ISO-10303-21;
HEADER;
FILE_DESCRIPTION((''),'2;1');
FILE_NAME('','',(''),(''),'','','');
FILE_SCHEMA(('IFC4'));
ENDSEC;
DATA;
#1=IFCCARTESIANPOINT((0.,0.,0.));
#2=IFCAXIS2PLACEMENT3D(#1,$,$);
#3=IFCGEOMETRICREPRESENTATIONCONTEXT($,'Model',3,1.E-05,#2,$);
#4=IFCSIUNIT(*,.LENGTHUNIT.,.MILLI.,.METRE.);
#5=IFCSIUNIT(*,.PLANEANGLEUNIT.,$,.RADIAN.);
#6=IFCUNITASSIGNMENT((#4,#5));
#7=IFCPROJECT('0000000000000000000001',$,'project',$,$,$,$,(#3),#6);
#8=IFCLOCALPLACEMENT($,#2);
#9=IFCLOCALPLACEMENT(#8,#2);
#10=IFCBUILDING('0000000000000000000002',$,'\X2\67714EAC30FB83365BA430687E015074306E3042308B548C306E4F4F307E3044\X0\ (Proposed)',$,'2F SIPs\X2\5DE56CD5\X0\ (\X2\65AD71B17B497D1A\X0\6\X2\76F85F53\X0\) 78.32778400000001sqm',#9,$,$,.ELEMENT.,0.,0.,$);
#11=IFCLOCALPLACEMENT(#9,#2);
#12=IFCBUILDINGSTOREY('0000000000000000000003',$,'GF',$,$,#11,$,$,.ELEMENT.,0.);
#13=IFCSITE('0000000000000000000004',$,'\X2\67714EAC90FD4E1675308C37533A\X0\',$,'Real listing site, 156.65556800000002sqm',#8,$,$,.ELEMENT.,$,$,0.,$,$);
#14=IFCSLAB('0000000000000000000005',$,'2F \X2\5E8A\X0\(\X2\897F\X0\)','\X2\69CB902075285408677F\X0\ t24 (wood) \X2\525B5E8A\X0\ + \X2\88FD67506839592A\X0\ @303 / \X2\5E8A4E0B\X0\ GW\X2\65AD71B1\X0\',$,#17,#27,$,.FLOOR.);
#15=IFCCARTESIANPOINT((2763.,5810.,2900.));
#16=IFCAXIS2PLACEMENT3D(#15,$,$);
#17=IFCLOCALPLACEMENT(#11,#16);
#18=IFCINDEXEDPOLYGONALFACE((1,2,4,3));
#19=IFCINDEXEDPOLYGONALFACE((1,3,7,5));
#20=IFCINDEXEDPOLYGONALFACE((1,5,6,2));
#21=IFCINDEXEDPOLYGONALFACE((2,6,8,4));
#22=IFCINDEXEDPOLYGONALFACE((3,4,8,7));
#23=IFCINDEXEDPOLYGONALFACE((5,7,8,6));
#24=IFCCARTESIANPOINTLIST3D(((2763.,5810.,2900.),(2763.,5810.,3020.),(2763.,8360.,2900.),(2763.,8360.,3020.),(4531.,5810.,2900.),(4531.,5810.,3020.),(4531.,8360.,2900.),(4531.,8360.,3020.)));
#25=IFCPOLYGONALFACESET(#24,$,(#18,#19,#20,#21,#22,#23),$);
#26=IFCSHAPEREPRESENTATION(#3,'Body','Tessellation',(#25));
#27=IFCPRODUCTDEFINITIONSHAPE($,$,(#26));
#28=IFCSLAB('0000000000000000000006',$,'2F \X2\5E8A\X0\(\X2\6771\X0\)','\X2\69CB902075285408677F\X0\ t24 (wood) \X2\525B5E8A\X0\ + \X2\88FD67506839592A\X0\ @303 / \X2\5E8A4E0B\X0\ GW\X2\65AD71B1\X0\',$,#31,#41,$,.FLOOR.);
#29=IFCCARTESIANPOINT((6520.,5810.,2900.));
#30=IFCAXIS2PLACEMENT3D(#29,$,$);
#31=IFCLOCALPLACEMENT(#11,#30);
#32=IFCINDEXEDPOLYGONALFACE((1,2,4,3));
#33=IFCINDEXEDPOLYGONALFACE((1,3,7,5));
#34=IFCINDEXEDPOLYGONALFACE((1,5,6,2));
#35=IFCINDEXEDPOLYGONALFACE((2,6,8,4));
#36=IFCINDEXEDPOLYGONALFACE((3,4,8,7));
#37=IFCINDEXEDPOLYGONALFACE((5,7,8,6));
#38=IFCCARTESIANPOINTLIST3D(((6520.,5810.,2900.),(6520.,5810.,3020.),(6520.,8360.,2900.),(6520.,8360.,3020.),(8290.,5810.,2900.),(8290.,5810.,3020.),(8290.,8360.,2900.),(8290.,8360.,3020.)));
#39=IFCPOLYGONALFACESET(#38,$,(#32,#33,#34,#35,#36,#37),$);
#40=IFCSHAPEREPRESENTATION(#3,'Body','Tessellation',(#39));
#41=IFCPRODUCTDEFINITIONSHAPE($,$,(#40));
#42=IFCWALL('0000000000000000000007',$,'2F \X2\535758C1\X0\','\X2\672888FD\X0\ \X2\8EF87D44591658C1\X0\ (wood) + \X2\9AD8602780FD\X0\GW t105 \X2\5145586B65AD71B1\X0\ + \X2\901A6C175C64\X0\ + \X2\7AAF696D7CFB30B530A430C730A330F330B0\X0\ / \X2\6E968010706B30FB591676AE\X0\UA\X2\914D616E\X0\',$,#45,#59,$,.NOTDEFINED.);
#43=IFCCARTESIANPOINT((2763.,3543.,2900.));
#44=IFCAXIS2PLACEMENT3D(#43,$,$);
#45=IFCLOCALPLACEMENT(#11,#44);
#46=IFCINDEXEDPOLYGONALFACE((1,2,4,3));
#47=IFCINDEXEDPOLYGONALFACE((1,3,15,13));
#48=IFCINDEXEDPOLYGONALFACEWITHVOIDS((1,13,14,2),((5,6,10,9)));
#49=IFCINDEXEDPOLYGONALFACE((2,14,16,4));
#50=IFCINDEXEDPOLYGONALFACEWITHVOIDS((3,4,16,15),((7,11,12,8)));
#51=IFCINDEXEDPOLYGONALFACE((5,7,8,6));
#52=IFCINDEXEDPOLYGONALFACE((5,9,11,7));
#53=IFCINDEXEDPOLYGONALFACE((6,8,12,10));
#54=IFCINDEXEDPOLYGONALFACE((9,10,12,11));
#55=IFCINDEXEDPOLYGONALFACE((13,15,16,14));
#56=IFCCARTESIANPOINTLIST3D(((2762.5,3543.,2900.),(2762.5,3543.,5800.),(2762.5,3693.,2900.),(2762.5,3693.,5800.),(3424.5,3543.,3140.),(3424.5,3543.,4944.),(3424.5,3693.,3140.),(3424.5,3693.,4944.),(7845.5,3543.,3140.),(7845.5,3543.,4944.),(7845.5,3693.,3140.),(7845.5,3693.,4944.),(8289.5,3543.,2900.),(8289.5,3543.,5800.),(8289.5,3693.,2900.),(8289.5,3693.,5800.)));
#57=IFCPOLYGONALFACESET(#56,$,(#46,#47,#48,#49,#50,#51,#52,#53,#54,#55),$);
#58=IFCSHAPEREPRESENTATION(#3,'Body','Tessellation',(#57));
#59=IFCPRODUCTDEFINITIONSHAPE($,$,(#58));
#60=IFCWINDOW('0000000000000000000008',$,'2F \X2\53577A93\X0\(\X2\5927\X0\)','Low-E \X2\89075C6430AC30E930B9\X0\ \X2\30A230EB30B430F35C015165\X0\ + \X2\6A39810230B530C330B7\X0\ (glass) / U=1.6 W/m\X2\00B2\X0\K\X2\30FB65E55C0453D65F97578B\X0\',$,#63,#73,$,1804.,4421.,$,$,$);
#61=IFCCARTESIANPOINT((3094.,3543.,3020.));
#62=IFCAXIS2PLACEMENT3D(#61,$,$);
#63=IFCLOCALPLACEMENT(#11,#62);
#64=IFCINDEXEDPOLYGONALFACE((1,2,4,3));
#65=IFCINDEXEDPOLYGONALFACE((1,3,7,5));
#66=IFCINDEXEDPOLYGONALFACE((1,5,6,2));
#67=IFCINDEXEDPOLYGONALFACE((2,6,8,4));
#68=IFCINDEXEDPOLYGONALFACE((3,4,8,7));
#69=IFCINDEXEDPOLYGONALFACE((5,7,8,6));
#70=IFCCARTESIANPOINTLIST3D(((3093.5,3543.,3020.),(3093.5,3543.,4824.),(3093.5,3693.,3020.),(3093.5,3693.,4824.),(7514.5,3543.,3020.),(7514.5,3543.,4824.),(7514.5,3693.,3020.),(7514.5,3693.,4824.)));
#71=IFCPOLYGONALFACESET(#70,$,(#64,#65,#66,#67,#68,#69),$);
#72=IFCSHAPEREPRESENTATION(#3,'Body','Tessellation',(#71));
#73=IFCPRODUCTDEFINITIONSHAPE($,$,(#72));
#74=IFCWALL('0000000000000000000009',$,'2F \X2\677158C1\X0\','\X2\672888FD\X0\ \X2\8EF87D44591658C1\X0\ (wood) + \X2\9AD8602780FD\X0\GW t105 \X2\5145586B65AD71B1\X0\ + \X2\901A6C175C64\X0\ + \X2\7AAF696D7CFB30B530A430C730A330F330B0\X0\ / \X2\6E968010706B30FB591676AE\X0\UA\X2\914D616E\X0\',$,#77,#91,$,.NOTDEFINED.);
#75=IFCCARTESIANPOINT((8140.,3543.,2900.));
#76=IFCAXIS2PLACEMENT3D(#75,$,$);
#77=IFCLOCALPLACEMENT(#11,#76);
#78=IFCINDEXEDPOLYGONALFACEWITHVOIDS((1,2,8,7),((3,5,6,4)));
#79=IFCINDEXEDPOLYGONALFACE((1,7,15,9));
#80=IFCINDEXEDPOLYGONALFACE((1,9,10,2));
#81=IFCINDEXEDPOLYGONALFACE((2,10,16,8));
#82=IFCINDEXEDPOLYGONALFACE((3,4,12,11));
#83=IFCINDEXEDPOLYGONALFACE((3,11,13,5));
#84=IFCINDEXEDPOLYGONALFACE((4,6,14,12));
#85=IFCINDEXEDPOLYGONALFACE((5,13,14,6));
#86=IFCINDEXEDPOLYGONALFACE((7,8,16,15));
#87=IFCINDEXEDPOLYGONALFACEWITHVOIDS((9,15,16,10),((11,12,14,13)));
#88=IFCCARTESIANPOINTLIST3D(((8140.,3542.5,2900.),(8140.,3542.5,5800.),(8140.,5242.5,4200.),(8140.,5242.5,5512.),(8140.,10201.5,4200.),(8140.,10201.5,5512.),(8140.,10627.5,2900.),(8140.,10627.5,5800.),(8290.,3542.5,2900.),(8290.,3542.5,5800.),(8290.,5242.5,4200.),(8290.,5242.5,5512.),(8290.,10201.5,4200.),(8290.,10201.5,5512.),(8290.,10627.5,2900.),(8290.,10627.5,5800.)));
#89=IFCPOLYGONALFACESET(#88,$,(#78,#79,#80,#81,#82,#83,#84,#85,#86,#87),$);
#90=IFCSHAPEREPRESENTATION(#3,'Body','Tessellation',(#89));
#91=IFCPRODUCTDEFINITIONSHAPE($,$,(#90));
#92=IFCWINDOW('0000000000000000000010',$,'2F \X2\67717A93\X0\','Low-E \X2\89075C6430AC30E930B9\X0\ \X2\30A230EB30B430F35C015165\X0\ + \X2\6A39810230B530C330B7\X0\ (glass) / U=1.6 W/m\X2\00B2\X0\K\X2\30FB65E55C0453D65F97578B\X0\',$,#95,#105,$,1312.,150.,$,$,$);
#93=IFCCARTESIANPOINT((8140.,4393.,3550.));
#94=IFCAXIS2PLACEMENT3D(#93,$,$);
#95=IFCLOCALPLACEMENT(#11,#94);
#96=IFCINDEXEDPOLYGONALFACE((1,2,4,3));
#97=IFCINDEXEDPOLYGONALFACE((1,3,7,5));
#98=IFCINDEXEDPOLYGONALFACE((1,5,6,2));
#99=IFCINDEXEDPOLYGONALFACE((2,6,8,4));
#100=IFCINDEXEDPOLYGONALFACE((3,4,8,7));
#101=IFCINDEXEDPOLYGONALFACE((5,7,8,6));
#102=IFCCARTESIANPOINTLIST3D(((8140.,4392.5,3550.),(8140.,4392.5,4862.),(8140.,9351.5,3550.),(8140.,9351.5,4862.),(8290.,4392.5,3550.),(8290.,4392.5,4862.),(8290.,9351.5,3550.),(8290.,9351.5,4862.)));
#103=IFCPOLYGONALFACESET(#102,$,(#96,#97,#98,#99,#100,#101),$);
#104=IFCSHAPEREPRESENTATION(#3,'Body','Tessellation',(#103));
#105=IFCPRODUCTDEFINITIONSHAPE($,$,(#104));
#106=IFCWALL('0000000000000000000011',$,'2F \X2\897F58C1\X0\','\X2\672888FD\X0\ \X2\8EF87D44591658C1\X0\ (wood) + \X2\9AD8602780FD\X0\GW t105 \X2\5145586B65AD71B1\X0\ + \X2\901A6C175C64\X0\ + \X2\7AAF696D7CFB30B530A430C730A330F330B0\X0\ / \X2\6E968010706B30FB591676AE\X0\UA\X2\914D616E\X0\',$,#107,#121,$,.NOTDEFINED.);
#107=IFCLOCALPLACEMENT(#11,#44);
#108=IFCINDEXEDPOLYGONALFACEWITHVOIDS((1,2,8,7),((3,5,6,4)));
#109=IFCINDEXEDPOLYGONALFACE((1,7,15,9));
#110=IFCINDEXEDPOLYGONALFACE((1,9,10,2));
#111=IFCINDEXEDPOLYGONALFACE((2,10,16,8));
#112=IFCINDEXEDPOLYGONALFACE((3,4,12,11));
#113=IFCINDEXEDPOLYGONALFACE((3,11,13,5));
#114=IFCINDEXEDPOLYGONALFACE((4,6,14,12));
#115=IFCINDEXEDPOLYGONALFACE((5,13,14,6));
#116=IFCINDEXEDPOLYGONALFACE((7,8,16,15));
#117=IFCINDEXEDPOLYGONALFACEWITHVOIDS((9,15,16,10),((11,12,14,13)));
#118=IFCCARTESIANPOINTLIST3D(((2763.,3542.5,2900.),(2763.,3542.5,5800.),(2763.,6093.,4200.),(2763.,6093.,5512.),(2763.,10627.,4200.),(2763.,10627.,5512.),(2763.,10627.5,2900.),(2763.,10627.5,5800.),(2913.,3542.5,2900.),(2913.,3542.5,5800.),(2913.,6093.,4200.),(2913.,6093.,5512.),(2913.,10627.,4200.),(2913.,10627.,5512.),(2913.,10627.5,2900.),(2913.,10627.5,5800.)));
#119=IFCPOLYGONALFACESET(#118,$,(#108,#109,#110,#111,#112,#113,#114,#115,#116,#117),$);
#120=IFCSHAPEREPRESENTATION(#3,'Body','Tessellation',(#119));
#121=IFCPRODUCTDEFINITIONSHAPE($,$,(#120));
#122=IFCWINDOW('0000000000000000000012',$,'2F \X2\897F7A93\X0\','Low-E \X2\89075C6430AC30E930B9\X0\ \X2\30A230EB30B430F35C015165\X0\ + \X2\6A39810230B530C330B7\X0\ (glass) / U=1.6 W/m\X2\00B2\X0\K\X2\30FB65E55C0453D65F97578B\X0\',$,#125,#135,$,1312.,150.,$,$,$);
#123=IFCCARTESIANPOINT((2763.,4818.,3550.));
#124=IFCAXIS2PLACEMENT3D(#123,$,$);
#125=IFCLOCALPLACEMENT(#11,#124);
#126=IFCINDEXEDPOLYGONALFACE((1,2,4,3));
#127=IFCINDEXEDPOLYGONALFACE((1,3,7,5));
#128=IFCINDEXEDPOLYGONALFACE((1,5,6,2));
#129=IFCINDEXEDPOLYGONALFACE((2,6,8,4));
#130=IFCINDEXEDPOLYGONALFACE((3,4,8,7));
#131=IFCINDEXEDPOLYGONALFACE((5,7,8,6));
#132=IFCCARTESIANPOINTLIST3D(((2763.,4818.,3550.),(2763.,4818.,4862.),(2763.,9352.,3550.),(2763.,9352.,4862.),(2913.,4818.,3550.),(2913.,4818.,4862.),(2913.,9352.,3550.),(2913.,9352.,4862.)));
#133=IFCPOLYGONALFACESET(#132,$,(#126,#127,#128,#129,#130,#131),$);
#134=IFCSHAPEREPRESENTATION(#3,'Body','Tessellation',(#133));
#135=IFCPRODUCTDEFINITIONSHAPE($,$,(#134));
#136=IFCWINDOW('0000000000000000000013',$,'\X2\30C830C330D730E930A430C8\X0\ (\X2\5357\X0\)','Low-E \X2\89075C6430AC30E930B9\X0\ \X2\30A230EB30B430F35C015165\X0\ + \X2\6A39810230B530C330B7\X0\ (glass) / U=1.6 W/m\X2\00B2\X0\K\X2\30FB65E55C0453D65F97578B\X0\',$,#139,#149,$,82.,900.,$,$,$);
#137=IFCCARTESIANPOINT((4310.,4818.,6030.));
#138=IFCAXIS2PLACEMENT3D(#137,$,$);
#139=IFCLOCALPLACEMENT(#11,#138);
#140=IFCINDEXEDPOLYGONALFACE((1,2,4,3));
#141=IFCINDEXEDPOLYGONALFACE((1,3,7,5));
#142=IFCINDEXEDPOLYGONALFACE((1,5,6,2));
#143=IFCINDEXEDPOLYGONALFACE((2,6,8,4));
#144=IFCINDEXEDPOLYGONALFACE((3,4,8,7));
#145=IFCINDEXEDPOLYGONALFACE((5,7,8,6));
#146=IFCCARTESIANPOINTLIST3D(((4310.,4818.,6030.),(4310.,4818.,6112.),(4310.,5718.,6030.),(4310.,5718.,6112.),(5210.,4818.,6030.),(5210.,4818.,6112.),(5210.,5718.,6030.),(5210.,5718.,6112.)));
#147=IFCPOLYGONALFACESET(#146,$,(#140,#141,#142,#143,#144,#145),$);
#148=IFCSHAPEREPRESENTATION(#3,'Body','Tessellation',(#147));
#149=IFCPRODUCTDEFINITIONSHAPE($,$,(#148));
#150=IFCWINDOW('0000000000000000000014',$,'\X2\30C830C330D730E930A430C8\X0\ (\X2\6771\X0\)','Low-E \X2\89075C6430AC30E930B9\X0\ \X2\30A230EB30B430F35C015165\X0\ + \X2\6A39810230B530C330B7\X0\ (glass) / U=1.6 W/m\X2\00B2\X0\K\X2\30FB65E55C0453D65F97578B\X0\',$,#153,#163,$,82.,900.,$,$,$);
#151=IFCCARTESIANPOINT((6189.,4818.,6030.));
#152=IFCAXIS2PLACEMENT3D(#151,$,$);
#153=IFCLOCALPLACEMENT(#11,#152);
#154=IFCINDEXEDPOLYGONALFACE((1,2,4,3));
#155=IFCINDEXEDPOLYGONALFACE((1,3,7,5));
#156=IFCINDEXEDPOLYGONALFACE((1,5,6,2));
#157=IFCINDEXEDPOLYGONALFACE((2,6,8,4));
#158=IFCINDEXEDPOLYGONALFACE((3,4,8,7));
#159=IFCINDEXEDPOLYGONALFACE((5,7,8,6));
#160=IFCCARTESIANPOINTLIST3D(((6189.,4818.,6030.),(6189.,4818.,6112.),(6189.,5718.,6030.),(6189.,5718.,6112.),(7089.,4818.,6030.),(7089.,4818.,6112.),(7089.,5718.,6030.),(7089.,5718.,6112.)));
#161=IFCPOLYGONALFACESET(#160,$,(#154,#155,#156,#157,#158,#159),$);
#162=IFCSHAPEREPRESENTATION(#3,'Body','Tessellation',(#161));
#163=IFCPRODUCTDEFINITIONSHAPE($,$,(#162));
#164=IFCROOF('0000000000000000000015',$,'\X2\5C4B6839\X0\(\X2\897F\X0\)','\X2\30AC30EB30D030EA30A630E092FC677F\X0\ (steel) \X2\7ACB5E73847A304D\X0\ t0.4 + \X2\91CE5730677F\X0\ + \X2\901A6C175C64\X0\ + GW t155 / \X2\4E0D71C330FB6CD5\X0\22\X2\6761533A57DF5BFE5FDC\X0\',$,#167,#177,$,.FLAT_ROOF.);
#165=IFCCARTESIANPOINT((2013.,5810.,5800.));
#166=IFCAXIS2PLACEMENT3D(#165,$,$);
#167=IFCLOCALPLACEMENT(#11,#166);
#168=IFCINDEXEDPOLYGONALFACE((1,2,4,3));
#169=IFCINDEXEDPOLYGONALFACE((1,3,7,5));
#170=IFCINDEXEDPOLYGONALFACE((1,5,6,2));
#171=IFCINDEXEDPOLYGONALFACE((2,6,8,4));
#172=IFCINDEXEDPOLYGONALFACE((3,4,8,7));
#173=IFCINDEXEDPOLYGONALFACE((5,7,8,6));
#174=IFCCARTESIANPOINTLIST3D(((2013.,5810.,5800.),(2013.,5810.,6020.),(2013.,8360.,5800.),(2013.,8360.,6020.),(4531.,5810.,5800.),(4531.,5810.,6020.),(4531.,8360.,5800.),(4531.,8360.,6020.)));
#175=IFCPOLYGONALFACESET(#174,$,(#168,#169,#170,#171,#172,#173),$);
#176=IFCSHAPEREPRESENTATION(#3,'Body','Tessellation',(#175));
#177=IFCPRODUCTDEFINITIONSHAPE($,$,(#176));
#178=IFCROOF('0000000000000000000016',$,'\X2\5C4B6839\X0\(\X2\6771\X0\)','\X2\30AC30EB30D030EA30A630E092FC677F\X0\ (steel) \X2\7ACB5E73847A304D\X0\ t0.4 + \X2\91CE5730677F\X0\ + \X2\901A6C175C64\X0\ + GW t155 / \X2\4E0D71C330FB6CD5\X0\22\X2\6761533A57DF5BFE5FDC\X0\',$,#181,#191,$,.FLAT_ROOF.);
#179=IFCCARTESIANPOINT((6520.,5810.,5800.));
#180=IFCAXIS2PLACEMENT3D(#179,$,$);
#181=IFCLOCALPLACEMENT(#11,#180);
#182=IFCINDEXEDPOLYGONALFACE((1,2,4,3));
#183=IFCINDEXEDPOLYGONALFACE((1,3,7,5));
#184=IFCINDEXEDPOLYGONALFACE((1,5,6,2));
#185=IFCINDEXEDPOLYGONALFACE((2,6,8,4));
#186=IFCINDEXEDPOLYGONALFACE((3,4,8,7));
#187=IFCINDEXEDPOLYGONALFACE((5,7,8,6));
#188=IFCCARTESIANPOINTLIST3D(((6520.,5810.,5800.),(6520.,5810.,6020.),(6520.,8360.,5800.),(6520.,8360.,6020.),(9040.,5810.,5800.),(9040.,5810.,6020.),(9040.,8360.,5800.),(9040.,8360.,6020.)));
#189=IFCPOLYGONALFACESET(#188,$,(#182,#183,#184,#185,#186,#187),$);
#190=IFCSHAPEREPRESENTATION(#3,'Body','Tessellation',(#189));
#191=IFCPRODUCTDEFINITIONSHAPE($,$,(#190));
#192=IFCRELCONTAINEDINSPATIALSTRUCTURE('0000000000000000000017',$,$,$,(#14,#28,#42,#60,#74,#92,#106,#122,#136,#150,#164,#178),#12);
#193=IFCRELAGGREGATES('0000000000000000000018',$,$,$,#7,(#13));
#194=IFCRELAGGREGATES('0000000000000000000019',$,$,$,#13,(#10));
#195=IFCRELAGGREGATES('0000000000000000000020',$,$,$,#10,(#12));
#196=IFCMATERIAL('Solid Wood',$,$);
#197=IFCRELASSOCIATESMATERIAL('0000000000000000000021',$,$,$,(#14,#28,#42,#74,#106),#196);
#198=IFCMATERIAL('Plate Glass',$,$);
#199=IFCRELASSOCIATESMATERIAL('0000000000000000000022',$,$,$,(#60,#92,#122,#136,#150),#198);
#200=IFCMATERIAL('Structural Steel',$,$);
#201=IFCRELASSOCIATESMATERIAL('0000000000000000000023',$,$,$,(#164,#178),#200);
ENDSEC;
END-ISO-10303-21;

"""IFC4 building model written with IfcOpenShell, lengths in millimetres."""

from ifc_helpers import new_model, si_unit, frame, frame_2d, origin, place, context, project, spatial, rectangle, extrude, material, element, fill, save


model = new_model("IFC4")

# Units and contexts
model_context = context("Model", 3, precision=1e-05, world=origin())
ifc_project = project(units=[si_unit("LENGTHUNIT", "METRE", prefix="MILLI"), si_unit("PLANEANGLEUNIT", "RADIAN")], contexts=[model_context])

# Site, building, storey
site_placement = place(None, origin())
site = spatial("IfcSite", under=ifc_project, at=site_placement, Name="東京都世田谷区", ObjectType="Real listing site, 156.65556800000002sqm", CompositionType="ELEMENT", RefElevation=0.0)
building_placement = place(site_placement, origin())
building = spatial("IfcBuilding", under=site, at=building_placement, Name="東京・茶室と縁側のある和の住まい (Proposed)", ObjectType="2F SIPs工法 (断熱等級6相当) 78.32778400000001sqm", CompositionType="ELEMENT", ElevationOfRefHeight=0.0, ElevationOfTerrain=0.0)
storey_placement = place(building_placement, origin())
storey = spatial("IfcBuildingStorey", under=building, at=storey_placement, Name="GF", CompositionType="ELEMENT", Elevation=0.0)

# Slabs
ifc_material_1 = material(Name="Solid Wood")
slab_1_placement = place(storey_placement, frame((2763.0, 5810.0, 2900.0)))
element("IfcSlab", 1, at=slab_1_placement, inside=storey, material=ifc_material_1, Name="2F 床(西)", Description="構造用合板 t24 (wood) 剛床 + 製材根太 @303 / 床下 GW断熱", PredefinedType="FLOOR", context=model_context, shape_type="SweptSolid", body=[
    extrude(rectangle(XDim=1768.0, YDim=2550.0, at=frame_2d((884.0, 1275.0))), frame((2763.0, 5810.0, 2900.0)), (0.0, 0.0, 1.0), 120.0),
])
slab_2_placement = place(storey_placement, frame((6520.0, 5810.0, 2900.0)))
element("IfcSlab", 2, at=slab_2_placement, inside=storey, material=ifc_material_1, Name="2F 床(東)", Description="構造用合板 t24 (wood) 剛床 + 製材根太 @303 / 床下 GW断熱", PredefinedType="FLOOR", context=model_context, shape_type="SweptSolid", body=[
    extrude(rectangle(XDim=1770.0, YDim=2550.0, at=frame_2d((885.0, 1275.0))), frame((6520.0, 5810.0, 2900.0)), (0.0, 0.0, 1.0), 120.0),
])

# Walls, openings, windows
wall_1_placement = place(storey_placement, frame((2763.0, 3543.0, 2900.0)))
wall_1 = element("IfcWall", 3, at=wall_1_placement, inside=storey, material=ifc_material_1, Name="2F 南壁", Description="木製 軸組外壁 (wood) + 高性能GW t105 充填断熱 + 通気層 + 窯業系サイディング / 準耐火・外皮UA配慮", PredefinedType="NOTDEFINED", context=model_context, shape_type="SweptSolid", body=[
    extrude(rectangle(XDim=5527.0, YDim=150.0, at=frame_2d((2763.0, 75.0))), frame((2763.0, 3543.0, 2900.0)), (0.0, 0.0, 1.0), 2900.0),
])
opening_1_placement = place(storey_placement, frame((3094.0, 3543.0, 3020.0)))
opening_1 = element("IfcOpeningElement", 4, at=opening_1_placement, cuts=wall_1, PredefinedType="NOTDEFINED", context=model_context, shape_type="SweptSolid", body=[
    extrude(rectangle(XDim=4421.0, YDim=150.0, at=frame_2d((2210.0, 75.0))), frame((3094.0, 3543.0, 3020.0)), (0.0, 0.0, 1.0), 1804.0),
])
ifc_material_2 = material(Name="Plate Glass")
window_1_placement = place(storey_placement, frame((3094.0, 3543.0, 3020.0)))
window_1 = element("IfcWindow", 5, at=window_1_placement, inside=storey, material=ifc_material_2, Name="2F 南窓(大)", Description="Low-E 複層ガラス アルゴン封入 + 樹脂サッシ (glass) / U=1.6 W/m²K・日射取得型", OverallHeight=1804.0, OverallWidth=4421.0, context=model_context, shape_type="SweptSolid", body=[
    extrude(rectangle(XDim=4421.0, YDim=150.0, at=frame_2d((2210.0, 75.0))), frame((3094.0, 3543.0, 3020.0)), (0.0, 0.0, 1.0), 1804.0),
])
fill(opening_1, window_1)
wall_2_placement = place(storey_placement, frame((8140.0, 3543.0, 2900.0)))
wall_2 = element("IfcWall", 6, at=wall_2_placement, inside=storey, material=ifc_material_1, Name="2F 東壁", Description="木製 軸組外壁 (wood) + 高性能GW t105 充填断熱 + 通気層 + 窯業系サイディング / 準耐火・外皮UA配慮", PredefinedType="NOTDEFINED", context=model_context, shape_type="SweptSolid", body=[
    extrude(rectangle(XDim=150.0, YDim=7085.0, at=frame_2d((75.0, 3542.0))), frame((8140.0, 3543.0, 2900.0)), (0.0, 0.0, 1.0), 2900.0),
])
opening_2_placement = place(storey_placement, frame((8140.0, 4393.0, 3550.0)))
opening_2 = element("IfcOpeningElement", 7, at=opening_2_placement, cuts=wall_2, PredefinedType="NOTDEFINED", context=model_context, shape_type="SweptSolid", body=[
    extrude(rectangle(XDim=150.0, YDim=4959.0, at=frame_2d((75.0, 2479.0))), frame((8140.0, 4393.0, 3550.0)), (0.0, 0.0, 1.0), 1312.0),
])
window_2_placement = place(storey_placement, frame((8140.0, 4393.0, 3550.0)))
window_2 = element("IfcWindow", 8, at=window_2_placement, inside=storey, material=ifc_material_2, Name="2F 東窓", Description="Low-E 複層ガラス アルゴン封入 + 樹脂サッシ (glass) / U=1.6 W/m²K・日射取得型", OverallHeight=1312.0, OverallWidth=150.0, context=model_context, shape_type="SweptSolid", body=[
    extrude(rectangle(XDim=150.0, YDim=4959.0, at=frame_2d((75.0, 2479.0))), frame((8140.0, 4393.0, 3550.0)), (0.0, 0.0, 1.0), 1312.0),
])
fill(opening_2, window_2)
wall_3_placement = place(storey_placement, frame((2763.0, 3543.0, 2900.0)))
wall_3 = element("IfcWall", 9, at=wall_3_placement, inside=storey, material=ifc_material_1, Name="2F 西壁", Description="木製 軸組外壁 (wood) + 高性能GW t105 充填断熱 + 通気層 + 窯業系サイディング / 準耐火・外皮UA配慮", PredefinedType="NOTDEFINED", context=model_context, shape_type="SweptSolid", body=[
    extrude(rectangle(XDim=150.0, YDim=7085.0, at=frame_2d((75.0, 3542.0))), frame((2763.0, 3543.0, 2900.0)), (0.0, 0.0, 1.0), 2900.0),
])
opening_3_placement = place(storey_placement, frame((2763.0, 4818.0, 3550.0)))
opening_3 = element("IfcOpeningElement", 10, at=opening_3_placement, cuts=wall_3, PredefinedType="NOTDEFINED", context=model_context, shape_type="SweptSolid", body=[
    extrude(rectangle(XDim=150.0, YDim=4534.0, at=frame_2d((75.0, 2267.0))), frame((2763.0, 4818.0, 3550.0)), (0.0, 0.0, 1.0), 1312.0),
])
window_3_placement = place(storey_placement, frame((2763.0, 4818.0, 3550.0)))
window_3 = element("IfcWindow", 11, at=window_3_placement, inside=storey, material=ifc_material_2, Name="2F 西窓", Description="Low-E 複層ガラス アルゴン封入 + 樹脂サッシ (glass) / U=1.6 W/m²K・日射取得型", OverallHeight=1312.0, OverallWidth=150.0, context=model_context, shape_type="SweptSolid", body=[
    extrude(rectangle(XDim=150.0, YDim=4534.0, at=frame_2d((75.0, 2267.0))), frame((2763.0, 4818.0, 3550.0)), (0.0, 0.0, 1.0), 1312.0),
])
fill(opening_3, window_3)

# Windows
window_4_placement = place(storey_placement, frame((4310.0, 4818.0, 6030.0)))
element("IfcWindow", 12, at=window_4_placement, inside=storey, material=ifc_material_2, Name="トップライト (南)", Description="Low-E 複層ガラス アルゴン封入 + 樹脂サッシ (glass) / U=1.6 W/m²K・日射取得型", OverallHeight=82.0, OverallWidth=900.0, context=model_context, shape_type="SweptSolid", body=[
    extrude(rectangle(XDim=900.0, YDim=900.0, at=frame_2d((450.0, 450.0))), frame((4310.0, 4818.0, 6030.0)), (0.0, 0.0, 1.0), 82.0),
])
window_5_placement = place(storey_placement, frame((6189.0, 4818.0, 6030.0)))
element("IfcWindow", 13, at=window_5_placement, inside=storey, material=ifc_material_2, Name="トップライト (東)", Description="Low-E 複層ガラス アルゴン封入 + 樹脂サッシ (glass) / U=1.6 W/m²K・日射取得型", OverallHeight=82.0, OverallWidth=900.0, context=model_context, shape_type="SweptSolid", body=[
    extrude(rectangle(XDim=900.0, YDim=900.0, at=frame_2d((450.0, 450.0))), frame((6189.0, 4818.0, 6030.0)), (0.0, 0.0, 1.0), 82.0),
])

# Roofs
ifc_material_3 = material(Name="Structural Steel")
roof_1_placement = place(storey_placement, frame((2013.0, 5810.0, 5800.0)))
element("IfcRoof", 14, at=roof_1_placement, inside=storey, material=ifc_material_3, Name="屋根(西)", Description="ガルバリウム鋼板 (steel) 立平葺き t0.4 + 野地板 + 通気層 + GW t155 / 不燃・法22条区域対応", PredefinedType="FLAT_ROOF", context=model_context, shape_type="SweptSolid", body=[
    extrude(rectangle(XDim=2518.0, YDim=2550.0, at=frame_2d((1259.0, 1275.0))), frame((2013.0, 5810.0, 5800.0)), (0.0, 0.0, 1.0), 220.0),
])
roof_2_placement = place(storey_placement, frame((6520.0, 5810.0, 5800.0)))
element("IfcRoof", 15, at=roof_2_placement, inside=storey, material=ifc_material_3, Name="屋根(東)", Description="ガルバリウム鋼板 (steel) 立平葺き t0.4 + 野地板 + 通気層 + GW t155 / 不燃・法22条区域対応", PredefinedType="FLAT_ROOF", context=model_context, shape_type="SweptSolid", body=[
    extrude(rectangle(XDim=2520.0, YDim=2550.0, at=frame_2d((1260.0, 1275.0))), frame((6520.0, 5810.0, 5800.0)), (0.0, 0.0, 1.0), 220.0),
])

save(model, "model.ifc")
